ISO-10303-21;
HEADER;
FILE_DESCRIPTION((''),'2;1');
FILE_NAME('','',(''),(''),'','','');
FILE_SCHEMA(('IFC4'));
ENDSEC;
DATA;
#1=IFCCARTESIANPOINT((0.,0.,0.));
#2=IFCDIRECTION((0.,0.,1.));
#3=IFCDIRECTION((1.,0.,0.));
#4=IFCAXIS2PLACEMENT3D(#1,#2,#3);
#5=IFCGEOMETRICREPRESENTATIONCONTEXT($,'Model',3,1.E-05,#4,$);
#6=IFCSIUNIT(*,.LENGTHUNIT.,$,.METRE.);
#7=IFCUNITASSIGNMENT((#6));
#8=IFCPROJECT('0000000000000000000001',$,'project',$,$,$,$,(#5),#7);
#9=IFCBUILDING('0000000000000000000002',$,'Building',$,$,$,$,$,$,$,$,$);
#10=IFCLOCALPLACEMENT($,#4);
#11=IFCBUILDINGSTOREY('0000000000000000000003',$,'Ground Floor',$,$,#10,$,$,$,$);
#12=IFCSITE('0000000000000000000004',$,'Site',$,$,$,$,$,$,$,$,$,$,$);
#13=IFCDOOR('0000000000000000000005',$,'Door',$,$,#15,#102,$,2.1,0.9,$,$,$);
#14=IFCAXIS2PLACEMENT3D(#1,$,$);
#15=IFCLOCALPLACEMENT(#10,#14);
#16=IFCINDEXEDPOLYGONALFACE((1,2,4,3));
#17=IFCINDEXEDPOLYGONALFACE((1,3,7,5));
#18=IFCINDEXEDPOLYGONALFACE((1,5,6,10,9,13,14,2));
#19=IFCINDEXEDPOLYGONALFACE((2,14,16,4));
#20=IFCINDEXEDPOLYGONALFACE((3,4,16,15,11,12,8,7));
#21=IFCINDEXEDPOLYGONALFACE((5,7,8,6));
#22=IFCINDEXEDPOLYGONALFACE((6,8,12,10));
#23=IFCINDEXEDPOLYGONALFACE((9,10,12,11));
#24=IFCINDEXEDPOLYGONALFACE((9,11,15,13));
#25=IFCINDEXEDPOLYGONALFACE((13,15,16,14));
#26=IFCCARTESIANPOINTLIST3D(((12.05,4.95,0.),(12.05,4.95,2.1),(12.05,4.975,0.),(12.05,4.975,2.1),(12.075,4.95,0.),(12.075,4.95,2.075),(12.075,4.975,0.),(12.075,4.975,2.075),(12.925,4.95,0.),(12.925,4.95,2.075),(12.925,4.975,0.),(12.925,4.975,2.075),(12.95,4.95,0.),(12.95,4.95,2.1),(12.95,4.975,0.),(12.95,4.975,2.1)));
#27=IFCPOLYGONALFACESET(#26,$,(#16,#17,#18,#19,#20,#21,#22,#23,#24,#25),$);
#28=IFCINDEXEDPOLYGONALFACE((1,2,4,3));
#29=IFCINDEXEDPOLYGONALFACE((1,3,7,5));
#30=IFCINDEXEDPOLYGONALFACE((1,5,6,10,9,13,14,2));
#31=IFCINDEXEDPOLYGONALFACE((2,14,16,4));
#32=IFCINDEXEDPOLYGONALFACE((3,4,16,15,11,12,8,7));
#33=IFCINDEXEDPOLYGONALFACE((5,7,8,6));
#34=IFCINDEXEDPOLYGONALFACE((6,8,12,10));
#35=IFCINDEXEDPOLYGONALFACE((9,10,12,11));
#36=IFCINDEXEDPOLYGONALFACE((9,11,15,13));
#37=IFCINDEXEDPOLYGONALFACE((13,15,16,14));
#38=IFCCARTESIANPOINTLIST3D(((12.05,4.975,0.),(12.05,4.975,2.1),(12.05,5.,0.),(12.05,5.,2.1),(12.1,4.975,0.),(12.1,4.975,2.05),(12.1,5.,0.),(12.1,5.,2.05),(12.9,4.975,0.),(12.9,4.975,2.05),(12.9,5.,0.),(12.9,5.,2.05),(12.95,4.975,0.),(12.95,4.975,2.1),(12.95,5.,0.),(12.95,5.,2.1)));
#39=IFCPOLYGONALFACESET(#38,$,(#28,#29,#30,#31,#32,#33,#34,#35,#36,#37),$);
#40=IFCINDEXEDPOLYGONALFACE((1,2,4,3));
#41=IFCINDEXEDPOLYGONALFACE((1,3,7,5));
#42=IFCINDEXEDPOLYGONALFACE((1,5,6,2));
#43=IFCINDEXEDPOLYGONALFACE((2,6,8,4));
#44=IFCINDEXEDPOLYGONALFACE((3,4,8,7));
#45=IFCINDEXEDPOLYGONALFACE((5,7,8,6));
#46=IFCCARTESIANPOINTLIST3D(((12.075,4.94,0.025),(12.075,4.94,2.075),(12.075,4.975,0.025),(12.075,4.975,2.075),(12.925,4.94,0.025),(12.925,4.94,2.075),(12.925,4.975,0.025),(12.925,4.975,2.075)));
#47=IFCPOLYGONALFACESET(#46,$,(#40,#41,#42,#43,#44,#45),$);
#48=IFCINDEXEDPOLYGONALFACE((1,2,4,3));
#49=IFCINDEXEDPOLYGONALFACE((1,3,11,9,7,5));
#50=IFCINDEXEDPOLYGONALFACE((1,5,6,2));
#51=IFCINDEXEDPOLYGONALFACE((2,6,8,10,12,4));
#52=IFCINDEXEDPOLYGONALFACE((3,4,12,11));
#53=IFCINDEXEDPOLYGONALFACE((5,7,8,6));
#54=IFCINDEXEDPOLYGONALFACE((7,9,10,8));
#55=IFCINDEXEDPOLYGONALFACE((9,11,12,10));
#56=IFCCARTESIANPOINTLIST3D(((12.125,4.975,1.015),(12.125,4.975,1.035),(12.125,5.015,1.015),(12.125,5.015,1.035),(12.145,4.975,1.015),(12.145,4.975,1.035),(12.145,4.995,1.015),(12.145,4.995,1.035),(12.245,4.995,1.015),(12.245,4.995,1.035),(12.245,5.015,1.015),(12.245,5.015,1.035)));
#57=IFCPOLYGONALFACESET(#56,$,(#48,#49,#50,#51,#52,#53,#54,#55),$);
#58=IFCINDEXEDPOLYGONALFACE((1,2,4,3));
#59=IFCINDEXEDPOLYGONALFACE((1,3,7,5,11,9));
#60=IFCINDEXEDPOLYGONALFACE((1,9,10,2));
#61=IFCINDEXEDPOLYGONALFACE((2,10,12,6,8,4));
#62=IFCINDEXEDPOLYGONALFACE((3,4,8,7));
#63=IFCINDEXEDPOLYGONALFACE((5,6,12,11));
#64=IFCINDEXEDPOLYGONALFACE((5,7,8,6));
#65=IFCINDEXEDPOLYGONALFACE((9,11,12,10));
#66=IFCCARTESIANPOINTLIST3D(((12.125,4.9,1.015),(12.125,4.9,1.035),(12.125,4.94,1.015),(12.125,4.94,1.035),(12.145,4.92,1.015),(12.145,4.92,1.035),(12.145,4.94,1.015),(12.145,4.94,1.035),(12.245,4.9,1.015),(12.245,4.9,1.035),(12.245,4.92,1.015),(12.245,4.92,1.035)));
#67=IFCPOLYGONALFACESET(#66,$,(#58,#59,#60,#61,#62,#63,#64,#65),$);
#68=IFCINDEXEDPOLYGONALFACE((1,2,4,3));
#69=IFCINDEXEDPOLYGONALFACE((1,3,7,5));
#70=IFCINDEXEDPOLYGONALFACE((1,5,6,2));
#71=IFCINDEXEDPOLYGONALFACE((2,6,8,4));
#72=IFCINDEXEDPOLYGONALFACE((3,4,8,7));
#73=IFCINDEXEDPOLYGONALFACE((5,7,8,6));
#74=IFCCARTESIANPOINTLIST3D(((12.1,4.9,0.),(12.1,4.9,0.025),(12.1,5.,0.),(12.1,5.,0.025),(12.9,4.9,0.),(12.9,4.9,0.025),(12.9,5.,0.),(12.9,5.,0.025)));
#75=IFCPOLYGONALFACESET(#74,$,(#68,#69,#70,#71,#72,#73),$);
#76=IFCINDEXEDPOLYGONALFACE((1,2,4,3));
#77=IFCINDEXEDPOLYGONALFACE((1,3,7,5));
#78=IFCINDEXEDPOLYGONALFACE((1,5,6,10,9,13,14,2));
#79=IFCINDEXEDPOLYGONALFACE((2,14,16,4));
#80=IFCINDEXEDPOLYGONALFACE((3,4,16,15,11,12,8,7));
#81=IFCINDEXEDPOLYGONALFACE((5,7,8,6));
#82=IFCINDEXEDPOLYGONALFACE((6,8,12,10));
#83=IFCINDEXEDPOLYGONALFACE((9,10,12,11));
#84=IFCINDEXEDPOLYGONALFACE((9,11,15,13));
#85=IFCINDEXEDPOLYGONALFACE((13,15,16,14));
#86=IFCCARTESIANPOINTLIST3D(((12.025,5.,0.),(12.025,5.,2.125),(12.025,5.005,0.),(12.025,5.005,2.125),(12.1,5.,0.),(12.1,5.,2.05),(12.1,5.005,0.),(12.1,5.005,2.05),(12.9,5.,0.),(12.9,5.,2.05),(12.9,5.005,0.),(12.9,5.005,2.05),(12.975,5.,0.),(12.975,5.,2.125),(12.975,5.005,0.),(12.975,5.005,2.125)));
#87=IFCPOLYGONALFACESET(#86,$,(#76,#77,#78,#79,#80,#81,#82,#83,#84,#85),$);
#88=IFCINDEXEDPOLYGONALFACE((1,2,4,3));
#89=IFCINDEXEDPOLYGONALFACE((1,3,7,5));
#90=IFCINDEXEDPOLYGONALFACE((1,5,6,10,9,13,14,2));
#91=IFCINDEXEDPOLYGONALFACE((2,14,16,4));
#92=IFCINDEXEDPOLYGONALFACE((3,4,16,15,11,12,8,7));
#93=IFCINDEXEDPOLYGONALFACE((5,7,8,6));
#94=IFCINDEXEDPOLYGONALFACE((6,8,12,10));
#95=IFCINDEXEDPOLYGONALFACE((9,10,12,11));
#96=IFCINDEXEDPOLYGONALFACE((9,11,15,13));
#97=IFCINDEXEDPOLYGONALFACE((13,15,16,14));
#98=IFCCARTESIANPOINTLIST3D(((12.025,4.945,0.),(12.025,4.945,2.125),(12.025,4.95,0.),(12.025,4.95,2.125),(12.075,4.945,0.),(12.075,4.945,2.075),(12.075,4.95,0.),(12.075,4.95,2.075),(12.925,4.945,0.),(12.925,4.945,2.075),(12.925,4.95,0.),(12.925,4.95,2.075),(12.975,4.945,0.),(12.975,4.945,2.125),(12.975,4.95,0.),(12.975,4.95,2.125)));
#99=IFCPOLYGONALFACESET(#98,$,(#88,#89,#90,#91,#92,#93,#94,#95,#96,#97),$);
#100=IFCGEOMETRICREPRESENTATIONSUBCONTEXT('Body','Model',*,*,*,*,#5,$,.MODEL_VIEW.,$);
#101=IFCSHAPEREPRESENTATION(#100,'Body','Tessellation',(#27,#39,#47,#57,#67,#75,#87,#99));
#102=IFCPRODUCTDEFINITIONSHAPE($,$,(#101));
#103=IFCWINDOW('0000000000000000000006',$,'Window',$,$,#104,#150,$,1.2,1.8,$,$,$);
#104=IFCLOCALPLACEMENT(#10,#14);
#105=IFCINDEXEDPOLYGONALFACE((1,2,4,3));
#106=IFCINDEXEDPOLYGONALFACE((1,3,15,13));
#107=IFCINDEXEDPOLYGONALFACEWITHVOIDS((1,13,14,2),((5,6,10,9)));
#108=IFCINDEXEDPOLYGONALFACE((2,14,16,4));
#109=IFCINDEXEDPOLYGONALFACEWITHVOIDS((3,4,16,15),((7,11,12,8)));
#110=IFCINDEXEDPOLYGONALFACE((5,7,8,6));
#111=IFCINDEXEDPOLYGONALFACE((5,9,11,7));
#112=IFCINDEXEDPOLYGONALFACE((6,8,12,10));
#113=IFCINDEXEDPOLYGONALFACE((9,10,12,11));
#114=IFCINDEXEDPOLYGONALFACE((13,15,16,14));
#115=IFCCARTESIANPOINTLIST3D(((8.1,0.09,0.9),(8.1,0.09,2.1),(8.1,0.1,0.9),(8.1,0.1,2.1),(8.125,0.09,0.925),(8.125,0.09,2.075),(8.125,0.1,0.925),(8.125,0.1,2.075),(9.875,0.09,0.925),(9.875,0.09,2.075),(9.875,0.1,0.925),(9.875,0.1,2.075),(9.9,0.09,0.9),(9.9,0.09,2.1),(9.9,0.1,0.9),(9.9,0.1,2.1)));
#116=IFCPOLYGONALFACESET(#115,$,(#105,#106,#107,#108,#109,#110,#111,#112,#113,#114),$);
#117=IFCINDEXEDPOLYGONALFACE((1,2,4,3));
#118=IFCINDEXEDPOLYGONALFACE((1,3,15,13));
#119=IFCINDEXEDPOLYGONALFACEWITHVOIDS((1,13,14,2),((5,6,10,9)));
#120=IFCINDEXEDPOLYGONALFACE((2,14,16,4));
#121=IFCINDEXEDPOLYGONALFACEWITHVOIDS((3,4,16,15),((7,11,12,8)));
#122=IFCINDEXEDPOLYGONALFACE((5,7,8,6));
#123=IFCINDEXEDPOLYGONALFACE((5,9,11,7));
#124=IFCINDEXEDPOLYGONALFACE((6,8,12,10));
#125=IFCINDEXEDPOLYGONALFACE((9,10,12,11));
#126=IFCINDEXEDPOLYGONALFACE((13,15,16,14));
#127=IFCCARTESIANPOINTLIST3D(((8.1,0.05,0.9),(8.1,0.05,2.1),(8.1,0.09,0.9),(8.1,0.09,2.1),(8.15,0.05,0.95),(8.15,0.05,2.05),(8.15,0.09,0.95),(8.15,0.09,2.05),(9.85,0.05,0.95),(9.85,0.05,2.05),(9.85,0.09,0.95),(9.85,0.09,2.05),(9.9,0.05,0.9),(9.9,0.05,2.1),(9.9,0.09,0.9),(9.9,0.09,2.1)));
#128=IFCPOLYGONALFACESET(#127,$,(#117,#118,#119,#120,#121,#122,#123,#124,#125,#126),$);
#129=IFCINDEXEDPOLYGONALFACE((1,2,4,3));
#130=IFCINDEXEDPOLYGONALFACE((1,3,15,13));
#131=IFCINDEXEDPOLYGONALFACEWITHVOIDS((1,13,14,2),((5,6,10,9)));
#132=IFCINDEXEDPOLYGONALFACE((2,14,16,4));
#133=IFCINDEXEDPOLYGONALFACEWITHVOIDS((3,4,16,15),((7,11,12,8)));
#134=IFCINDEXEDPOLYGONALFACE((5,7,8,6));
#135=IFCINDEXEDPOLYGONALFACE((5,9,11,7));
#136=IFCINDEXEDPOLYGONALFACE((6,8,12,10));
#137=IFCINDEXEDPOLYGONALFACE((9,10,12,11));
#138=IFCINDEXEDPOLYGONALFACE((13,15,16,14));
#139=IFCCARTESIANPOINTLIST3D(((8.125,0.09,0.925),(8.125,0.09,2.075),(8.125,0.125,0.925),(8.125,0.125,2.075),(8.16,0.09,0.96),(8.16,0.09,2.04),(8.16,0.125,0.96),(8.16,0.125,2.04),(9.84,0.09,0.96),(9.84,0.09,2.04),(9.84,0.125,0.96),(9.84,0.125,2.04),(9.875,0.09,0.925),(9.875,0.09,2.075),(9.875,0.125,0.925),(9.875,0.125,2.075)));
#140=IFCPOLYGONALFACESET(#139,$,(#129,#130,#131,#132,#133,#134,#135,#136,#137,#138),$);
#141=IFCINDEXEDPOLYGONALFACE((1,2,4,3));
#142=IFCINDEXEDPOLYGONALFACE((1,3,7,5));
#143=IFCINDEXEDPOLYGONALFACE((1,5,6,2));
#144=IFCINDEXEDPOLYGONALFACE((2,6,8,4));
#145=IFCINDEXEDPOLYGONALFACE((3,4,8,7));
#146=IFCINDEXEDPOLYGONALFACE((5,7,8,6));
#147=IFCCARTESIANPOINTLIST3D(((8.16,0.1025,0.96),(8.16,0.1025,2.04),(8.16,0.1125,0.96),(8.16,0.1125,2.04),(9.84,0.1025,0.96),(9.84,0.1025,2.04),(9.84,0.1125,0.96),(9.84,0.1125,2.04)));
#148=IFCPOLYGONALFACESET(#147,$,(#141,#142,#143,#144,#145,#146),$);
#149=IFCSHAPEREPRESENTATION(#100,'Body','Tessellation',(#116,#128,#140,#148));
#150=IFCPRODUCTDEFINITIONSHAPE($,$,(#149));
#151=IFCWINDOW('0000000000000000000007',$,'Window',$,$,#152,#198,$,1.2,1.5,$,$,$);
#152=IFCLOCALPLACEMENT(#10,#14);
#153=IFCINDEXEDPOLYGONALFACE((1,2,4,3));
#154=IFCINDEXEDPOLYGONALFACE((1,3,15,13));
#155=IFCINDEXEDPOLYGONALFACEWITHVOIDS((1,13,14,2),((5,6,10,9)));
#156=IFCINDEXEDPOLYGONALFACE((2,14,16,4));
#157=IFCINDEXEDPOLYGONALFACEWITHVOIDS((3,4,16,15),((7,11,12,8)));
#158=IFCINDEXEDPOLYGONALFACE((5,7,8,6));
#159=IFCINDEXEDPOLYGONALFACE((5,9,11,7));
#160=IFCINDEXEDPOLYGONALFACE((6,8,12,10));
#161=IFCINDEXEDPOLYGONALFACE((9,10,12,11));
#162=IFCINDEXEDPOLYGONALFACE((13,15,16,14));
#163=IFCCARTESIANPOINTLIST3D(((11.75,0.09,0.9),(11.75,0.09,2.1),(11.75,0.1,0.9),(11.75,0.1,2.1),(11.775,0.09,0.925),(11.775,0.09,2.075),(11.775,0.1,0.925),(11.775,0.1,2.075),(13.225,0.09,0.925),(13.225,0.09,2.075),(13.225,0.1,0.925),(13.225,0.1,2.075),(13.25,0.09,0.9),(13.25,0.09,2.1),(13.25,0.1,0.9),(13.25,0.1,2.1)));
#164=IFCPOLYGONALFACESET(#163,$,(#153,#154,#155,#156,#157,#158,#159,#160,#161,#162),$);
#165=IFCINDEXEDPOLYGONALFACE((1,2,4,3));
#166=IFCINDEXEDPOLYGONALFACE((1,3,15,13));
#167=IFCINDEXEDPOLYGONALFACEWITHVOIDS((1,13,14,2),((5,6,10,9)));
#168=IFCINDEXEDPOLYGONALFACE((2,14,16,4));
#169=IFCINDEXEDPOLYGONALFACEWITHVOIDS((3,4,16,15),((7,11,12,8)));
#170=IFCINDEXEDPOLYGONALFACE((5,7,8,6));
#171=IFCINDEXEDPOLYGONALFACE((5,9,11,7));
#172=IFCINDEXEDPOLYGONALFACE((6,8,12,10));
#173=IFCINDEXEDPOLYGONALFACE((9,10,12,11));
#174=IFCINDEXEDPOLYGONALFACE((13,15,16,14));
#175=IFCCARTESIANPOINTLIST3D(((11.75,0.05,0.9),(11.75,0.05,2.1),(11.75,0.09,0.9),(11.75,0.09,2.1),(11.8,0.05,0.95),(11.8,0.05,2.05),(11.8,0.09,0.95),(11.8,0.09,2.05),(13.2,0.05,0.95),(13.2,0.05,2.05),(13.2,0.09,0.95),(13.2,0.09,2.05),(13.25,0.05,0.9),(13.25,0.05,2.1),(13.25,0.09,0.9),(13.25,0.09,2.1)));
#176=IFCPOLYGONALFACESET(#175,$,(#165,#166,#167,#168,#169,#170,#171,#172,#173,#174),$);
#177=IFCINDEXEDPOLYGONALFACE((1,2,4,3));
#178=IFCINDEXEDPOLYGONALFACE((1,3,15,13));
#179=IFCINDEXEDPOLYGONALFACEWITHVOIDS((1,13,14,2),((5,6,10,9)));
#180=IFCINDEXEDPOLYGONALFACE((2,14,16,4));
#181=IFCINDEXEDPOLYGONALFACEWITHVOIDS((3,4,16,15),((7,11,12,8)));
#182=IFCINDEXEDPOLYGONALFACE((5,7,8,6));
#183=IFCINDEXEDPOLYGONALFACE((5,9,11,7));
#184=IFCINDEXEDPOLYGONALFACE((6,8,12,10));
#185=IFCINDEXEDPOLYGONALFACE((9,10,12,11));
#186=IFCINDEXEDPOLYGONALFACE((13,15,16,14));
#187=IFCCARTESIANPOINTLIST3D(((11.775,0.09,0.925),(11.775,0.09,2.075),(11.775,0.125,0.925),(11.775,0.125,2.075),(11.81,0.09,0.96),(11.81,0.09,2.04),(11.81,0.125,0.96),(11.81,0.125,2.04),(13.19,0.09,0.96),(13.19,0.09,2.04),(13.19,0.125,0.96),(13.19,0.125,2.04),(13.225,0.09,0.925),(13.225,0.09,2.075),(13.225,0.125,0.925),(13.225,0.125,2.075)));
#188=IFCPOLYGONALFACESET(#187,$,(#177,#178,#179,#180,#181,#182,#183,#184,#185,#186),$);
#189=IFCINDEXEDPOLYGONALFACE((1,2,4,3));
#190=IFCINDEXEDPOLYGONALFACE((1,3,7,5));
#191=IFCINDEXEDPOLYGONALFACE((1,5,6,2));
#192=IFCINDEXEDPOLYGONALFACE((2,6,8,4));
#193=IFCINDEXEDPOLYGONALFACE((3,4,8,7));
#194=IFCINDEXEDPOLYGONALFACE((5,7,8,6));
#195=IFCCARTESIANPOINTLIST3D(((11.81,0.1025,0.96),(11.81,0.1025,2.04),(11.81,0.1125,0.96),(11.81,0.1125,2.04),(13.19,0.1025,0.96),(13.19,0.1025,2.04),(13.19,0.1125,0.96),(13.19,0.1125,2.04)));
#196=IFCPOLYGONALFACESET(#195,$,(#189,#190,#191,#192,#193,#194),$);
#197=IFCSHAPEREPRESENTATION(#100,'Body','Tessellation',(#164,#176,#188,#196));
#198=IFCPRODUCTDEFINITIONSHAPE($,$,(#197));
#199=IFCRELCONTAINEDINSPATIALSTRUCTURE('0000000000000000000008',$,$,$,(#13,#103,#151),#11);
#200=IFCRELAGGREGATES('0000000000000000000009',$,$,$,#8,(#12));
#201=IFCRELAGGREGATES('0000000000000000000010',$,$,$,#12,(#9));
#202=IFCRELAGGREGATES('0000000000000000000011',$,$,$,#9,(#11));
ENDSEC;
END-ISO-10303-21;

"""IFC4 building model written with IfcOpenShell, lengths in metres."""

from ifc_helpers import new_model, si_unit, frame, origin_with_axes, place, context, subcontext, project, spatial, line, indexed_curve, outline, extrude, element, save


model = new_model("IFC4")

# Units and contexts
model_context = context("Model", 3, precision=1e-05, world=origin_with_axes())
body_context = subcontext(model_context, "Body", "Model", "MODEL_VIEW")
ifc_project = project(units=[si_unit("LENGTHUNIT", "METRE")], contexts=[model_context])

# Site, building, storey
site = spatial("IfcSite", under=ifc_project, Name="Site")
building = spatial("IfcBuilding", under=site, Name="Building")
storey_placement = place(None, origin_with_axes())
storey = spatial("IfcBuildingStorey", under=building, at=storey_placement, Name="Ground Floor")

# Door
door_1_placement = place(storey_placement, frame((12.95, 5.0, 0.0), z_axis=(0.0, 0.0, 1.0), x_axis=(-1.0, 0.0, 0.0)))
element("IfcDoor", 1, at=door_1_placement, inside=storey, Name="Door", OverallHeight=2.1, OverallWidth=0.9, context=body_context, shape_type="SweptSolid", body=[
    extrude(outline(indexed_curve([(0.0, 0.0), (0.0, 2.1), (0.9, 2.1), (0.9, 0.0), (0.875, 0.0), (0.875, 2.075), (0.025, 2.075), (0.025, 0.0)], segments=[line(1, 2, 3, 4, 5, 6, 7, 8, 1)])), frame((0.0, 0.025, 0.0), z_axis=(0.0, -1.0, 0.0), x_axis=(1.0, 0.0, 0.0)), (0.0, 0.0, -1.0), 0.025),
    extrude(outline(indexed_curve([(0.0, 0.0), (0.0, 2.1), (0.9, 2.1), (0.9, 0.0), (0.85, 0.0), (0.85, 2.05), (0.05, 2.05), (0.05, 0.0)], segments=[line(1, 2, 3, 4, 5, 6, 7, 8, 1)])), frame((0.0, 0.0, 0.0), z_axis=(0.0, -1.0, 0.0), x_axis=(1.0, 0.0, 0.0)), (0.0, 0.0, -1.0), 0.025),
    extrude(outline(indexed_curve([(0.0, 0.0), (0.85, 0.0), (0.85, 0.035), (0.0, 0.035)], segments=[line(1, 2, 3, 4, 1)])), frame((0.025, 0.025, 0.025), z_axis=(0.0, 0.0, 1.0), x_axis=(1.0, 0.0, 0.0)), (0.0, 0.0, 1.0), 2.05),
    extrude(outline(indexed_curve([(0.0, 0.0), (0.0, -0.04), (-0.12, -0.04), (-0.12, -0.02), (-0.02, -0.02), (-0.02, 0.0)], segments=[line(1, 2, 3, 4, 5, 6, 1)])), frame((0.825, 0.025, 1.015), z_axis=(0.0, 0.0, 1.0), x_axis=(1.0, 0.0, 0.0)), (0.0, 0.0, 1.0), 0.02),
    extrude(outline(indexed_curve([(0.0, 0.0), (0.0, 0.04), (-0.12, 0.04), (-0.12, 0.02), (-0.02, 0.02), (-0.02, 0.0)], segments=[line(1, 2, 3, 4, 5, 6, 1)])), frame((0.825, 0.06, 1.015), z_axis=(0.0, 0.0, 1.0), x_axis=(1.0, 0.0, 0.0)), (0.0, 0.0, 1.0), 0.02),
    extrude(outline(indexed_curve([(0.0, 0.0), (0.8, 0.0), (0.8, 0.1), (0.0, 0.1)], segments=[line(1, 2, 3, 4, 1)])), frame((0.05, 0.0, 0.0), z_axis=(0.0, 0.0, 1.0), x_axis=(1.0, 0.0, 0.0)), (0.0, 0.0, 1.0), 0.025),
    extrude(outline(indexed_curve([(0.0, 0.0), (0.0, 2.125), (0.95, 2.125), (0.95, 0.0), (0.875, 0.0), (0.875, 2.05), (0.075, 2.05), (0.075, 0.0)], segments=[line(1, 2, 3, 4, 5, 6, 7, 8, 1)])), frame((-0.025, -0.005, 0.0), z_axis=(0.0, -1.0, 0.0), x_axis=(1.0, 0.0, 0.0)), (0.0, 0.0, -1.0), 0.005),
    extrude(outline(indexed_curve([(0.0, 0.0), (0.0, 2.125), (0.95, 2.125), (0.95, 0.0), (0.9, 0.0), (0.9, 2.075), (0.05, 2.075), (0.05, 0.0)], segments=[line(1, 2, 3, 4, 5, 6, 7, 8, 1)])), frame((-0.025, 0.05, 0.0), z_axis=(0.0, -1.0, 0.0), x_axis=(1.0, 0.0, 0.0)), (0.0, 0.0, -1.0), 0.005),
])

# Windows
window_placement = place(storey_placement, frame((8.1, 0.0, 0.9), z_axis=(0.0, 0.0, 1.0), x_axis=(1.0, 0.0, 0.0)))
element("IfcWindow", 2, at=window_placement, inside=storey, Name="Window", OverallHeight=1.2, OverallWidth=1.8, context=body_context, shape_type="SweptSolid", body=[
    extrude(outline(indexed_curve([(0.0, 0.0), (1.8, 0.0), (1.8, 1.2), (0.0, 1.2)], segments=[line(1, 2, 3, 4, 1)]), holes=[indexed_curve([(0.025, 0.025), (1.775, 0.025), (1.775, 1.175), (0.025, 1.175)], segments=[line(1, 2, 3, 4, 1)])]), frame((0.0, 0.09, 0.0), z_axis=(0.0, -1.0, 0.0), x_axis=(1.0, 0.0, 0.0)), (0.0, 0.0, -1.0), 0.01),
    extrude(outline(indexed_curve([(0.0, 0.0), (1.8, 0.0), (1.8, 1.2), (0.0, 1.2)], segments=[line(1, 2, 3, 4, 1)]), holes=[indexed_curve([(0.05, 0.05), (1.75, 0.05), (1.75, 1.15), (0.05, 1.15)], segments=[line(1, 2, 3, 4, 1)])]), frame((0.0, 0.05, 0.0), z_axis=(0.0, -1.0, 0.0), x_axis=(1.0, 0.0, 0.0)), (0.0, 0.0, -1.0), 0.04),
    extrude(outline(indexed_curve([(0.0, 0.0), (1.75, 0.0), (1.75, 1.15), (0.0, 1.15)], segments=[line(1, 2, 3, 4, 1)]), holes=[indexed_curve([(0.035, 0.035), (1.715, 0.035), (1.715, 1.115), (0.035, 1.115)], segments=[line(1, 2, 3, 4, 1)])]), frame((0.025, 0.09, 0.025), z_axis=(0.0, -1.0, 0.0), x_axis=(1.0, 0.0, 0.0)), (0.0, 0.0, -1.0), 0.035),
    extrude(outline(indexed_curve([(0.035, 0.035), (1.715, 0.035), (1.715, 1.115), (0.035, 1.115)], segments=[line(1, 2, 3, 4, 1)])), frame((0.025, 0.1025, 0.025), z_axis=(0.0, -1.0, 0.0), x_axis=(1.0, 0.0, 0.0)), (0.0, 0.0, -1.0), 0.01),
])
for number, where, z_axis, x_axis, name in (
    (3, (11.75, 0.0, 0.9), (0.0, 0.0, 1.0), (1.0, 0.0, 0.0), "Window"),
):
    element("IfcWindow", number, at=place(storey_placement, frame(where, z_axis=z_axis, x_axis=x_axis)), inside=storey, Name=name, OverallHeight=1.2, OverallWidth=1.5, context=body_context, shape_type="SweptSolid", body=[
        extrude(outline(indexed_curve([(0.0, 0.0), (1.5, 0.0), (1.5, 1.2), (0.0, 1.2)], segments=[line(1, 2, 3, 4, 1)]), holes=[indexed_curve([(0.025, 0.025), (1.475, 0.025), (1.475, 1.175), (0.025, 1.175)], segments=[line(1, 2, 3, 4, 1)])]), frame((0.0, 0.09, 0.0), z_axis=(0.0, -1.0, 0.0), x_axis=(1.0, 0.0, 0.0)), (0.0, 0.0, -1.0), 0.01),
        extrude(outline(indexed_curve([(0.0, 0.0), (1.5, 0.0), (1.5, 1.2), (0.0, 1.2)], segments=[line(1, 2, 3, 4, 1)]), holes=[indexed_curve([(0.05, 0.05), (1.45, 0.05), (1.45, 1.15), (0.05, 1.15)], segments=[line(1, 2, 3, 4, 1)])]), frame((0.0, 0.05, 0.0), z_axis=(0.0, -1.0, 0.0), x_axis=(1.0, 0.0, 0.0)), (0.0, 0.0, -1.0), 0.04),
        extrude(outline(indexed_curve([(0.0, 0.0), (1.45, 0.0), (1.45, 1.15), (0.0, 1.15)], segments=[line(1, 2, 3, 4, 1)]), holes=[indexed_curve([(0.035, 0.035), (1.415, 0.035), (1.415, 1.115), (0.035, 1.115)], segments=[line(1, 2, 3, 4, 1)])]), frame((0.025, 0.09, 0.025), z_axis=(0.0, -1.0, 0.0), x_axis=(1.0, 0.0, 0.0)), (0.0, 0.0, -1.0), 0.035),
        extrude(outline(indexed_curve([(0.035, 0.035), (1.415, 0.035), (1.415, 1.115), (0.035, 1.115)], segments=[line(1, 2, 3, 4, 1)])), frame((0.025, 0.1025, 0.025), z_axis=(0.0, -1.0, 0.0), x_axis=(1.0, 0.0, 0.0)), (0.0, 0.0, -1.0), 0.01),
    ])

save(model, "model.ifc")
